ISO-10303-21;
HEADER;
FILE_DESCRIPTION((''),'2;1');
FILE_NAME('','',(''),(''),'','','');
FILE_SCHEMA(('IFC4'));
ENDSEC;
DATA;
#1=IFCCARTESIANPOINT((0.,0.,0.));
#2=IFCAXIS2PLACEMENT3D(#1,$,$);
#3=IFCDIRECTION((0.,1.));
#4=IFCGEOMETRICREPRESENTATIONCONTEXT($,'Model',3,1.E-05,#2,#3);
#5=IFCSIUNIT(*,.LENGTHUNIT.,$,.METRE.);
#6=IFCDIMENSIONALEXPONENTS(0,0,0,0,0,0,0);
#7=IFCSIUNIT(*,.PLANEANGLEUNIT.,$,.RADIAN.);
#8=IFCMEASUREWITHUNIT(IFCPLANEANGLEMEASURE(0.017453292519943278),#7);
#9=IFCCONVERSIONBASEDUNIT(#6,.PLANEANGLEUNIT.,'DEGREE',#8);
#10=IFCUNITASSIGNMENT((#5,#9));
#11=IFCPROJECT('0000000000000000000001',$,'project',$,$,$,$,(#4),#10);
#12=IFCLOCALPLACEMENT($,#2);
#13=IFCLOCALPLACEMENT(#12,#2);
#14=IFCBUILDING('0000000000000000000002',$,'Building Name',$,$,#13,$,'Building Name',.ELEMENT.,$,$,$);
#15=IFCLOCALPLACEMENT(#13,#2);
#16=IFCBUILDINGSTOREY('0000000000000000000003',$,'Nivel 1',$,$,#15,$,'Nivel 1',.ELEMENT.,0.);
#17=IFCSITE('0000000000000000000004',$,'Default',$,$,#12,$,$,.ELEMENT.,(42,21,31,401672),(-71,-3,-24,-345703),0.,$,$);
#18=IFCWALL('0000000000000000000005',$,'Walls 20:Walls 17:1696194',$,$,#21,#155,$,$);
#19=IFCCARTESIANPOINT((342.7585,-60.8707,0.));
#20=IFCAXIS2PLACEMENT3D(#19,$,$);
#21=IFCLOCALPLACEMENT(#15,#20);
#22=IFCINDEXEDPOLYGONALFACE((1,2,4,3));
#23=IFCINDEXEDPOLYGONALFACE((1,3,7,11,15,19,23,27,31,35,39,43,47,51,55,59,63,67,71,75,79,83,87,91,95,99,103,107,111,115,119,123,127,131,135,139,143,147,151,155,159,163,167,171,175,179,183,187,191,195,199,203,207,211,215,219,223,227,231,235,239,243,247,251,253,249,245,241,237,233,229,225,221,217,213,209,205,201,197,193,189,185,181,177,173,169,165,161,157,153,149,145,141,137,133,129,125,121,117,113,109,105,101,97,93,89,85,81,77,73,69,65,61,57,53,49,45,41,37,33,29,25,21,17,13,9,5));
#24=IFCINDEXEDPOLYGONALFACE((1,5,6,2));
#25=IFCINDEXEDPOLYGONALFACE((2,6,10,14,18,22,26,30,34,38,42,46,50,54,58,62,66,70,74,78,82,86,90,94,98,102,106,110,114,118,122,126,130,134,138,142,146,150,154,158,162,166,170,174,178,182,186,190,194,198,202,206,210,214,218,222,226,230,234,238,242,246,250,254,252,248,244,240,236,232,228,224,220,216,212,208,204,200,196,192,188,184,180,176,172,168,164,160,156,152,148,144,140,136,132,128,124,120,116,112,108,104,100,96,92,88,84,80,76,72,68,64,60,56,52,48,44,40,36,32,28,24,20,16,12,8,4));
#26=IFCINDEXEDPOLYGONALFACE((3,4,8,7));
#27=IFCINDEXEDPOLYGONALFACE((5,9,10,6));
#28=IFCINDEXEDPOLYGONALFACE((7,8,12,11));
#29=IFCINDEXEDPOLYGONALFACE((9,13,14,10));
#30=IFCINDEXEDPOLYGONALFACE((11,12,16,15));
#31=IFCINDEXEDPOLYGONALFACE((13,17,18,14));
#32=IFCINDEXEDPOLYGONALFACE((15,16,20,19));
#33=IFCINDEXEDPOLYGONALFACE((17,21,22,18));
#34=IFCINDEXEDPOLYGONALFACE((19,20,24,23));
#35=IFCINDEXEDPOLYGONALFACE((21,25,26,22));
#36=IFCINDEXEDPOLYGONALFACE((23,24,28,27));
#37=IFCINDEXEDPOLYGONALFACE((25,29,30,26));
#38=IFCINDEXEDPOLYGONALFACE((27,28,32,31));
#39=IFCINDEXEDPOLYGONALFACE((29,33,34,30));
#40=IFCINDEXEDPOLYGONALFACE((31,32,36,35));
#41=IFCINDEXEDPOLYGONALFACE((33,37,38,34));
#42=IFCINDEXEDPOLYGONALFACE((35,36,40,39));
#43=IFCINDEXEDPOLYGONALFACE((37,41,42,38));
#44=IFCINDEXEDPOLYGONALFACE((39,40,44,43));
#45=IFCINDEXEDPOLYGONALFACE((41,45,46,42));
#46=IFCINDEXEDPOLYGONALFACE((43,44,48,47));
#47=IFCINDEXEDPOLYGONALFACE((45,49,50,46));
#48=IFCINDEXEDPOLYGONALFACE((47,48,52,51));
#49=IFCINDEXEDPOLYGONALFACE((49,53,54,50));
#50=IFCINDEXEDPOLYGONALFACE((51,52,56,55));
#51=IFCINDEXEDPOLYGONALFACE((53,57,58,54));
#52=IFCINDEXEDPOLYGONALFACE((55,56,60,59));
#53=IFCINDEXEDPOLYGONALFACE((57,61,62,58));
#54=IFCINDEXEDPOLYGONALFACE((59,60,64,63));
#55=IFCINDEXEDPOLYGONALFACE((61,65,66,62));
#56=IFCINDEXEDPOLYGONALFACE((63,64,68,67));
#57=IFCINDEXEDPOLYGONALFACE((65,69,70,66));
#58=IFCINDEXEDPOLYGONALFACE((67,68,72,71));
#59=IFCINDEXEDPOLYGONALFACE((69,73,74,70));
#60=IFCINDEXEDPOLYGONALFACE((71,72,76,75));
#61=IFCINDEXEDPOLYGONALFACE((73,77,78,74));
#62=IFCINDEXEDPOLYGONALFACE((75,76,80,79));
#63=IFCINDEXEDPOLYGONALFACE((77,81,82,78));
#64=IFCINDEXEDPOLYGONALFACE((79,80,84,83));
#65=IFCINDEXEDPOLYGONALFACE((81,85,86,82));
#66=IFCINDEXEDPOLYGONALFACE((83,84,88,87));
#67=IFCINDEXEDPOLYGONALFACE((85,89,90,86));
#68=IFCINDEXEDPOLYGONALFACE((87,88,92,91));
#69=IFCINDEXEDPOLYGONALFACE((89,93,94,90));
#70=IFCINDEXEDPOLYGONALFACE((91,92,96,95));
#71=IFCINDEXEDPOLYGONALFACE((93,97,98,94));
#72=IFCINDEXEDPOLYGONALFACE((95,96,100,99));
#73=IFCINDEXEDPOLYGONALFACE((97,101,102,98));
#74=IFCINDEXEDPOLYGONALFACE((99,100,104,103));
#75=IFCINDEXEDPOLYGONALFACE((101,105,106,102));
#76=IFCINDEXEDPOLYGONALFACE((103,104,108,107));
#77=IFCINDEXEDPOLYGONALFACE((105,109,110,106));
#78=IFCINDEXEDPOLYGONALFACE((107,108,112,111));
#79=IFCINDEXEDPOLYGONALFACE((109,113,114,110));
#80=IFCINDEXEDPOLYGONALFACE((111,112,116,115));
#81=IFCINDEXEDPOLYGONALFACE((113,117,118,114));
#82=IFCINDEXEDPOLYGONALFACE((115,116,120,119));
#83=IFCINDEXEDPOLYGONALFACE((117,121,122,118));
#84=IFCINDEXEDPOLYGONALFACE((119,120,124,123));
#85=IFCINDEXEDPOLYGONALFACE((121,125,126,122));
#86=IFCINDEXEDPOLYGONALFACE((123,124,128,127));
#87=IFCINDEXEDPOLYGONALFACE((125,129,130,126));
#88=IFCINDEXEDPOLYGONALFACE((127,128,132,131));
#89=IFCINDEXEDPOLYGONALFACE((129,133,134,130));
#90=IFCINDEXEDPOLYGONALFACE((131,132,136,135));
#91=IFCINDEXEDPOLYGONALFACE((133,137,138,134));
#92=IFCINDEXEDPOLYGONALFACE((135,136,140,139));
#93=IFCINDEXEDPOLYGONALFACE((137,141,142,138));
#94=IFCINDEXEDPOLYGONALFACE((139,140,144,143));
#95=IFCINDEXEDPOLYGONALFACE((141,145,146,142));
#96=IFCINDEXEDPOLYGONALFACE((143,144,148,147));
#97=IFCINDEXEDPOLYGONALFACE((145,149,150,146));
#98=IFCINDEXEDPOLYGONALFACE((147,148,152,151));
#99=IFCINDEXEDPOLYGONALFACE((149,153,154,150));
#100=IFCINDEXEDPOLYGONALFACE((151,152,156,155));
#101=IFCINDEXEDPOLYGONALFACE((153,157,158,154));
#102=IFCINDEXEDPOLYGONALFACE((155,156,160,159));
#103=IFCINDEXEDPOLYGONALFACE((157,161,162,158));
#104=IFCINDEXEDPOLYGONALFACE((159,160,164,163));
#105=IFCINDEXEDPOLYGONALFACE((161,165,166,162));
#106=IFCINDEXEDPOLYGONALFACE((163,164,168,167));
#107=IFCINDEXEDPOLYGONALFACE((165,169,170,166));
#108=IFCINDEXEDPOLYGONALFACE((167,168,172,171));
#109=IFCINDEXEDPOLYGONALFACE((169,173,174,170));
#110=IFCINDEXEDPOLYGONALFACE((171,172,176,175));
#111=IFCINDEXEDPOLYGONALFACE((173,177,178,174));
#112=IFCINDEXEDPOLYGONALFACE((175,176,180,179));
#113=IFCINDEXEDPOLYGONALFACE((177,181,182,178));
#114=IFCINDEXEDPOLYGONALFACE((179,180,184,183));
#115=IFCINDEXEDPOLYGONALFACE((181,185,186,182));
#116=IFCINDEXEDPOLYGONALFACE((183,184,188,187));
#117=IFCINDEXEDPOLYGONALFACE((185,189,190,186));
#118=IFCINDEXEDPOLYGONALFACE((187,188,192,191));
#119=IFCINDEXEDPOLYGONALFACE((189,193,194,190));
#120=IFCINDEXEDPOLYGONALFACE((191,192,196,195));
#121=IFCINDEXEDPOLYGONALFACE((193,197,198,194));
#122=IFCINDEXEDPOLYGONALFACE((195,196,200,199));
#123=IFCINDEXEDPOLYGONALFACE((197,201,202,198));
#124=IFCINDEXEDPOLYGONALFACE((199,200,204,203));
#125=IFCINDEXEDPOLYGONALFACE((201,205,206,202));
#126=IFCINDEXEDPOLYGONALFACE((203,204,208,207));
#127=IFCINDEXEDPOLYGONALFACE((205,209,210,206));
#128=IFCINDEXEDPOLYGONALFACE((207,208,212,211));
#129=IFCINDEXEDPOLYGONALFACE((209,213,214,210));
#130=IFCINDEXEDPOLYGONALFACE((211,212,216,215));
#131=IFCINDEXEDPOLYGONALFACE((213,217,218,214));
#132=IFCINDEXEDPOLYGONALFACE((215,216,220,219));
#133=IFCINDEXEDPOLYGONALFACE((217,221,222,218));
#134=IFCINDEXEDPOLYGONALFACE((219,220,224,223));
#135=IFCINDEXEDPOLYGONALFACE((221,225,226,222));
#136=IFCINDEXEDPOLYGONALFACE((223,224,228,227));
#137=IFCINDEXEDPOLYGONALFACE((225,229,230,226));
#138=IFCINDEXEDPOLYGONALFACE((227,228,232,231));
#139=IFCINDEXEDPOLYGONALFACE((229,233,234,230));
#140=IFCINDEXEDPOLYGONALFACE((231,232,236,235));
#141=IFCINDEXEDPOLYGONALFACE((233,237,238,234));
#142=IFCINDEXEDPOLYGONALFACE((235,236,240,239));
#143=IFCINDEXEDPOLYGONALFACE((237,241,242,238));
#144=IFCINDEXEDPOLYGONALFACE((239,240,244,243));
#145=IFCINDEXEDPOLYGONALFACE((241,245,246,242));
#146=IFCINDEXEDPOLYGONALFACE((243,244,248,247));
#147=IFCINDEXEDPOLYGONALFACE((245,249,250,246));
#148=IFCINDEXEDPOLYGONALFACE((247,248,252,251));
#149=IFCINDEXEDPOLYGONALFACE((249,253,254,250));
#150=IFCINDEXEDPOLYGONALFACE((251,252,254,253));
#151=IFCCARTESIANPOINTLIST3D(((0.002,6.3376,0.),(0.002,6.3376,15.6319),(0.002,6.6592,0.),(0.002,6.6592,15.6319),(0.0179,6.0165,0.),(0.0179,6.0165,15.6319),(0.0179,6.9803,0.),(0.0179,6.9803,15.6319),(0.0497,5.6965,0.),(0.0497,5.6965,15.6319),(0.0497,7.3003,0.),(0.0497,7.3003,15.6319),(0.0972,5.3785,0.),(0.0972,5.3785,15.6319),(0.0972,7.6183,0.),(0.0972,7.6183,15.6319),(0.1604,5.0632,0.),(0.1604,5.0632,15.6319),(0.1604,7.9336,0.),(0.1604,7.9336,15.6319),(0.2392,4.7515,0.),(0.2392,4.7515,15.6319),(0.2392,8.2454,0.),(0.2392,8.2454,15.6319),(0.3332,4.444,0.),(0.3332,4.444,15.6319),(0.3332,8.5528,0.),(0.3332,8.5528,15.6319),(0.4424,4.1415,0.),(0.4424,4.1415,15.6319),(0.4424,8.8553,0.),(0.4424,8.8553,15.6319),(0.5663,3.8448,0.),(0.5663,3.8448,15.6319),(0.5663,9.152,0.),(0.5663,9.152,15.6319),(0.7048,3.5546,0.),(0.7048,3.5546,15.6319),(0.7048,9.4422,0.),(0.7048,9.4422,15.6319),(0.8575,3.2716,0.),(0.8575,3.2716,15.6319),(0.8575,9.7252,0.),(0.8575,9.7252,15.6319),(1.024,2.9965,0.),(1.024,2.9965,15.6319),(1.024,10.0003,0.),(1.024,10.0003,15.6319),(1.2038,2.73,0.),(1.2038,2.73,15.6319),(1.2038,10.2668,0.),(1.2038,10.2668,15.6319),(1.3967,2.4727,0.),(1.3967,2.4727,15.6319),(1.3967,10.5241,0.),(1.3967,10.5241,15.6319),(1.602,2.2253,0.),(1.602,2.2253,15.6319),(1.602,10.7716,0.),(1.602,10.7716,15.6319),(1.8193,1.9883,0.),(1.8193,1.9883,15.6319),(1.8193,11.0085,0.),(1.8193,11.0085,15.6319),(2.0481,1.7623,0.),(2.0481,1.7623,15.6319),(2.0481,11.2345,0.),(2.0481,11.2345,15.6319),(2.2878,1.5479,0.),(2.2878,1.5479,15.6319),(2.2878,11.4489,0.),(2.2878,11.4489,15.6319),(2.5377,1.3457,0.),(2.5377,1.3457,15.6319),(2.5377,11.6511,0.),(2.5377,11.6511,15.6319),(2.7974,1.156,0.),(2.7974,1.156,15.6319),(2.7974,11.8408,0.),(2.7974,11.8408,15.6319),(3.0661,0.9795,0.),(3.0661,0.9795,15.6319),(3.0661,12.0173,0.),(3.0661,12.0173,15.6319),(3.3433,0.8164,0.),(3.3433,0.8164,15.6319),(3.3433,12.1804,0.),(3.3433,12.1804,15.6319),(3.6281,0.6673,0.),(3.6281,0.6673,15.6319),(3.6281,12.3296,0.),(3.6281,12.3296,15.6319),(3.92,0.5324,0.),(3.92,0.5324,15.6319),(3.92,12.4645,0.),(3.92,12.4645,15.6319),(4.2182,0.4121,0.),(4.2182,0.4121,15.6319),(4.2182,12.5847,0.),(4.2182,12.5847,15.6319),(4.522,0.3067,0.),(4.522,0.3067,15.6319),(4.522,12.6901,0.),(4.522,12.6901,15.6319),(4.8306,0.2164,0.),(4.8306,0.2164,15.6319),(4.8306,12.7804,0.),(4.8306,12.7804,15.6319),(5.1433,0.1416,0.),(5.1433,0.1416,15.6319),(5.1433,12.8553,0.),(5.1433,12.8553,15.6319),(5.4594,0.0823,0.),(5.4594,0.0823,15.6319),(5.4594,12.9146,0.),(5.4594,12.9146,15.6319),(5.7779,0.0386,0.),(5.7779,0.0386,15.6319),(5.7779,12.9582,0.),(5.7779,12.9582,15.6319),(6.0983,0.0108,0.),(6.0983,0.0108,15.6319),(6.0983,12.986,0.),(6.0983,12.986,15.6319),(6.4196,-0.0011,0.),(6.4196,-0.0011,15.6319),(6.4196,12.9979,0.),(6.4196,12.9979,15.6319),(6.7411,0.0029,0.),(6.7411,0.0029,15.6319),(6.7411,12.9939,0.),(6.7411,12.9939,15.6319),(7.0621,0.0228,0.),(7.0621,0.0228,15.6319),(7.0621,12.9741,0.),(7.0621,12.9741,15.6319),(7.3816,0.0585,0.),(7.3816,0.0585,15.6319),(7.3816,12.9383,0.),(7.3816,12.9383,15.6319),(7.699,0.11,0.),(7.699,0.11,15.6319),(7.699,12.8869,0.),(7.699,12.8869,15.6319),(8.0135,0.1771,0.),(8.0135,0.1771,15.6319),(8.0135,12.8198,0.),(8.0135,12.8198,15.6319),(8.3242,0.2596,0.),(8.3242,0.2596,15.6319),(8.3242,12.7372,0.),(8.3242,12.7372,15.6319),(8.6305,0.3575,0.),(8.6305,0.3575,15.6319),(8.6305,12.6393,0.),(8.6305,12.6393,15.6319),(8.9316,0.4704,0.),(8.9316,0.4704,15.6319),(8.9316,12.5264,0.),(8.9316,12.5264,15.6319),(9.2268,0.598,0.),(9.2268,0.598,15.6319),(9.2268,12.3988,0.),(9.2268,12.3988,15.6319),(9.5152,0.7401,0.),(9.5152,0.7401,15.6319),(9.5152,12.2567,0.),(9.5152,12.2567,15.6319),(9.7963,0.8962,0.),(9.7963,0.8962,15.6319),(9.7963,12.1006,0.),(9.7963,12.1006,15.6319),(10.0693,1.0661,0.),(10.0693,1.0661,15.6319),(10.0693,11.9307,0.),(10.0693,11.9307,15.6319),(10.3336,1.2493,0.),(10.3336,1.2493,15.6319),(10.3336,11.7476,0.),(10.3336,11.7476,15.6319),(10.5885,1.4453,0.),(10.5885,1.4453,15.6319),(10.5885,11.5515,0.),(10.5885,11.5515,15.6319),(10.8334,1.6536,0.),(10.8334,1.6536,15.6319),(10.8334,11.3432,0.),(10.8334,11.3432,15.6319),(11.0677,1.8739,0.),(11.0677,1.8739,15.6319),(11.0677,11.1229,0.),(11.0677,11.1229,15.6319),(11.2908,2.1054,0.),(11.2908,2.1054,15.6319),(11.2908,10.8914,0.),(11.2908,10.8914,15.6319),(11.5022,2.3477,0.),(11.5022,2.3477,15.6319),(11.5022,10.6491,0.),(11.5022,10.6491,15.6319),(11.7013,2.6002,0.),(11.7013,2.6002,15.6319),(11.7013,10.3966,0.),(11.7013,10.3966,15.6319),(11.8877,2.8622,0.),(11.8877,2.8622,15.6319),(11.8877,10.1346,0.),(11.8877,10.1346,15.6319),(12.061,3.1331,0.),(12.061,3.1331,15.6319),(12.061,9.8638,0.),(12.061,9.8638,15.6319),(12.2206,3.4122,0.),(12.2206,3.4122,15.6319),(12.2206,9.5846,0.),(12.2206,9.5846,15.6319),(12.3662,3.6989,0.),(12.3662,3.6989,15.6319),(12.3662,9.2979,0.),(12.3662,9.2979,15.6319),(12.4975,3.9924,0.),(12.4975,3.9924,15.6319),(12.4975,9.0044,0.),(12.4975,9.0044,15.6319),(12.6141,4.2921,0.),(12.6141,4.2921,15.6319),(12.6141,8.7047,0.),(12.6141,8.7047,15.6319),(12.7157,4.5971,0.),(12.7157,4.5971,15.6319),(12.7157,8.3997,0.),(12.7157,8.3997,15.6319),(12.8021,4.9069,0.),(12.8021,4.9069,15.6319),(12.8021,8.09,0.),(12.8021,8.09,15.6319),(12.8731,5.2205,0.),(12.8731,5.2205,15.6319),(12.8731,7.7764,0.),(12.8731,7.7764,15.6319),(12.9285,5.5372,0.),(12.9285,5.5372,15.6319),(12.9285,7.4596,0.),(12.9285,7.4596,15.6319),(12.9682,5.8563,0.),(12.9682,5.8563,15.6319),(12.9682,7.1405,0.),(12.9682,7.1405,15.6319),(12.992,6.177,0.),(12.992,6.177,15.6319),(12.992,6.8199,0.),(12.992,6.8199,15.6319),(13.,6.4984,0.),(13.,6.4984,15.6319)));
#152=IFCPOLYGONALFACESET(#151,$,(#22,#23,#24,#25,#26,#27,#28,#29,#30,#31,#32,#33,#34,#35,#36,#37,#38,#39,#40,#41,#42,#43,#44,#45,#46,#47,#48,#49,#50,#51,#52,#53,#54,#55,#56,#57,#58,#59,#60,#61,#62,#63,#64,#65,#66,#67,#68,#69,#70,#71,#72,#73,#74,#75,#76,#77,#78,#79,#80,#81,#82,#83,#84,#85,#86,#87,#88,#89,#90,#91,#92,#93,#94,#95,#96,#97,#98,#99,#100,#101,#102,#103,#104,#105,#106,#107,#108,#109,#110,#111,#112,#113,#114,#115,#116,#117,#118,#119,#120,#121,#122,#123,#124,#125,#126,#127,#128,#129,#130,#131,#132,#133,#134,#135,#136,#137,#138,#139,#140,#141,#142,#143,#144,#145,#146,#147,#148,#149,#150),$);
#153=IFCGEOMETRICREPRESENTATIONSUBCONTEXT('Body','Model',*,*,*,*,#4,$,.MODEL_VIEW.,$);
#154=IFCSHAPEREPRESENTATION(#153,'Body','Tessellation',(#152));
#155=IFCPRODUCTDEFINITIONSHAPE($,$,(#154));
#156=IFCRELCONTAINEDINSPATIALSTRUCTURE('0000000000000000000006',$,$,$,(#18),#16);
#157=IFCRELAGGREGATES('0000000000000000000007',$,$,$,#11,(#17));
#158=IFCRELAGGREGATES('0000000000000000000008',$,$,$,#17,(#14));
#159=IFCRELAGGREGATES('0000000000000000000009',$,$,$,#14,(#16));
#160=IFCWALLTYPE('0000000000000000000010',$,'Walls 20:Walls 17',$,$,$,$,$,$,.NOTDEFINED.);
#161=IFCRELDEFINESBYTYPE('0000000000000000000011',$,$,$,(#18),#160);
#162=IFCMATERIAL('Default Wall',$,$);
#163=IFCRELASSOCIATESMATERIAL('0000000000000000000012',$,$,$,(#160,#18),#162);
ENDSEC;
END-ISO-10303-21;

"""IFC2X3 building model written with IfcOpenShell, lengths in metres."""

from ifc_helpers import new_model, entity, si_unit, converted_unit, direction, frame, frame_2d, origin, place, context, subcontext, project, spatial, circle, extrude, material, type_object, element, save


model = new_model("IFC2X3")

# Units and contexts
model_context = context("Model", 3, precision=1e-05, world=origin(), true_north=direction((0.0, 1.0)))
body_context = subcontext(model_context, "Body", "Model", "MODEL_VIEW")
ifc_project = project(units=[si_unit("LENGTHUNIT", "METRE"), converted_unit("PLANEANGLEUNIT", "DEGREE", entity("IfcPlaneAngleMeasure", 0.017453292519943278), si_unit("PLANEANGLEUNIT", "RADIAN"), dimensions=[0, 0, 0, 0, 0, 0, 0])], contexts=[model_context])

# Site, building, storey
site_placement = place(None, origin())
site = spatial("IfcSite", under=ifc_project, at=site_placement, Name="Default", CompositionType="ELEMENT", RefLatitude=(42, 21, 31, 401672), RefLongitude=(-71, -3, -24, -345703), RefElevation=0.0)
building_placement = place(site_placement, origin())
building = spatial("IfcBuilding", under=site, at=building_placement, Name="Building Name", LongName="Building Name", CompositionType="ELEMENT")
storey_placement = place(building_placement, origin())
storey = spatial("IfcBuildingStorey", under=building, at=storey_placement, Name="Nivel 1", LongName="Nivel 1", CompositionType="ELEMENT", Elevation=0.0)

# Wall
ifc_material_1 = material(Name="Default Wall")
wall_type_1 = type_object("IfcWallType", Name="Walls 20:Walls 17", PredefinedType="NOTDEFINED", material=ifc_material_1)
wall_1_placement = place(storey_placement, frame((342.7585, -60.8707, 0.0)))
element("IfcWall", 1, at=wall_1_placement, inside=storey, type_object=wall_type_1, material=ifc_material_1, Name="Walls 20:Walls 17:1696194", context=body_context, shape_type="SweptSolid", body=[
    extrude(circle(Radius=6.5, at=frame_2d((0.0, 0.0), x_axis=(1.0, 0.0))), frame((6.5, 6.4984, 0.0)), (0.0, 0.0, 1.0), 15.6319),
])

save(model, "model.ifc")
